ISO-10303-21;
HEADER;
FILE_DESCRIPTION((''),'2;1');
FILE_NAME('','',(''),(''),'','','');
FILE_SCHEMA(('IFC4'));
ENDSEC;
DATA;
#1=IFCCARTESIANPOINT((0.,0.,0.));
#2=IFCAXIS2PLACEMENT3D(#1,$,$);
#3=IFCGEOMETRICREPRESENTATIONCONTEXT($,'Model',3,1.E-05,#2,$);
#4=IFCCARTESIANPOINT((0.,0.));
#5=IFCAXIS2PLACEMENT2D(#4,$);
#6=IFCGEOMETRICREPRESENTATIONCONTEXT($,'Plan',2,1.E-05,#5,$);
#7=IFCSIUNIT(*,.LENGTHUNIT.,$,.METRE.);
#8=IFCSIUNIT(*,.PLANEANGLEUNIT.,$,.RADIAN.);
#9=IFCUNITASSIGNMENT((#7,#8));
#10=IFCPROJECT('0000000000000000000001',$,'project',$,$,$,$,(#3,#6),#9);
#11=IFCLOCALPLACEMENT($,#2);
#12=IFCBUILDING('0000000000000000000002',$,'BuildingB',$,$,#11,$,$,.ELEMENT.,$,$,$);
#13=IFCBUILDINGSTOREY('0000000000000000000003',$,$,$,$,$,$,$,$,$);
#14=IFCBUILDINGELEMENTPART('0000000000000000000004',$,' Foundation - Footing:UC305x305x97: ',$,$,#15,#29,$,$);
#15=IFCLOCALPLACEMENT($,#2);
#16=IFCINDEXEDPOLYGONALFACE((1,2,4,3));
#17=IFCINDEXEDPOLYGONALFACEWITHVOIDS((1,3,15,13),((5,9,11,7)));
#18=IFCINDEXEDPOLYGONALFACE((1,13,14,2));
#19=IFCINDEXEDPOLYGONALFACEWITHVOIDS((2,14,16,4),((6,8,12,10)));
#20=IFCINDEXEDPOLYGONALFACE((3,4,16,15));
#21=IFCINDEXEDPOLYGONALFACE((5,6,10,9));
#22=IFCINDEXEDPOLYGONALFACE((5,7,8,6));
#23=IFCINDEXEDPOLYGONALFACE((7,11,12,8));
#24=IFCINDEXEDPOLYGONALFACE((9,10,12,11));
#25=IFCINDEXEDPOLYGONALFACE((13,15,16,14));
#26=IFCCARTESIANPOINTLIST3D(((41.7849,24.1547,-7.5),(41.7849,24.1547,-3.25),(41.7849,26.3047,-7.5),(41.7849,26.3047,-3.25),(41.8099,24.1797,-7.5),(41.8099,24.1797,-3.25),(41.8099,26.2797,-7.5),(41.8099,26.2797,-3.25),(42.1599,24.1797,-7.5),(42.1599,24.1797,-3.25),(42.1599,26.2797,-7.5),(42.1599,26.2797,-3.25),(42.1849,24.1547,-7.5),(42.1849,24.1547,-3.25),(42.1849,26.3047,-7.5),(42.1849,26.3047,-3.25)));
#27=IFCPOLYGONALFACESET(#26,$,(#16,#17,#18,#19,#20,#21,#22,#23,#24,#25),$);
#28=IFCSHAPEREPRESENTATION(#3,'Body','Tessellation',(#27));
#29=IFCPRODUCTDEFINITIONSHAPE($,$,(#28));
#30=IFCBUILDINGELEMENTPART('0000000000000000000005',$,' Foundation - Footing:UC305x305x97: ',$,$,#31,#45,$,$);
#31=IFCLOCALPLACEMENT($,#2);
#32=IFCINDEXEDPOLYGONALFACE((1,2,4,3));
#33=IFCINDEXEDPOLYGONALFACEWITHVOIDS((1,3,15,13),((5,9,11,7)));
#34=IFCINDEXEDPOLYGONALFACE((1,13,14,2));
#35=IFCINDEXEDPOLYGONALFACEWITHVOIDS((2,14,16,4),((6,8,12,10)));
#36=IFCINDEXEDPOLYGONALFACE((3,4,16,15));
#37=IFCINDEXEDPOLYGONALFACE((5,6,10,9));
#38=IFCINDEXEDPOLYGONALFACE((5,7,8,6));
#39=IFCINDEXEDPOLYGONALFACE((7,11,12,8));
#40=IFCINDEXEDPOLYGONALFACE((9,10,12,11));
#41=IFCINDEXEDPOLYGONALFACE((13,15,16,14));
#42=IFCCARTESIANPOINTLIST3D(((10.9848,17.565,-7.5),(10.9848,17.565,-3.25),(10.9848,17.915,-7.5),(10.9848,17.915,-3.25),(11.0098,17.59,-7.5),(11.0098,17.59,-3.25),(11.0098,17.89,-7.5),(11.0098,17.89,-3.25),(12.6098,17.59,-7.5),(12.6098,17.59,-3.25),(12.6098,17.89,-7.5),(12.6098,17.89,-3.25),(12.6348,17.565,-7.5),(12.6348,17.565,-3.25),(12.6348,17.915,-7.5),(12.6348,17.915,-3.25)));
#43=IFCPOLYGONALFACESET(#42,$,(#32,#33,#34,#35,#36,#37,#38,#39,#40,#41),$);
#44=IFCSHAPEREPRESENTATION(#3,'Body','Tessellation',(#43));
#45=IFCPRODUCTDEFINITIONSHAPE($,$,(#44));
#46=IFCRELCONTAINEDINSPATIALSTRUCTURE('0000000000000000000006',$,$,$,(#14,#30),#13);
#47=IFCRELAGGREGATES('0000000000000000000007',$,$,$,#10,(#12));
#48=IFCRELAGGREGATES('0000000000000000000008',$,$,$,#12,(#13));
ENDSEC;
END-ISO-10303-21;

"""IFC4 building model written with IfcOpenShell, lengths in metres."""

from ifc_helpers import new_model, si_unit, origin, origin_2d, place, context, project, spatial, polyline, outline, extrude, element, save


model = new_model("IFC4")

# Units and contexts
model_context = context("Model", 3, precision=1e-05, world=origin())
plan_context = context("Plan", 2, precision=1e-05, world=origin_2d())
ifc_project = project(units=[si_unit("LENGTHUNIT", "METRE"), si_unit("PLANEANGLEUNIT", "RADIAN")], contexts=[model_context, plan_context])

# Building, storey
building_placement = place(None, origin())
building = spatial("IfcBuilding", under=ifc_project, at=building_placement, Name="BuildingB", CompositionType="ELEMENT")
storey = spatial("IfcBuildingStorey", under=building)

# Building element parts, openings
building_element_part_1 = element("IfcBuildingElementPart", 1, inside=storey, Name=" Foundation - Footing:UC305x305x97: ", context=model_context, shape_type="SweptSolid", body=[
    extrude(outline(polyline([(41.7849, 26.3047, -7.5), (42.1849, 26.3047, -7.5), (42.1849, 24.1547, -7.5), (41.7849, 24.1547, -7.5), (41.7849, 26.3047, -7.5)])), None, (0.0, 0.0, 1.0), 4.25),
])
element("IfcOpeningElement", 2, inside=storey, cuts=building_element_part_1, context=model_context, shape_type="SweptSolid", body=[
    extrude(outline(polyline([(41.8099, 26.2797, -7.5), (42.1599, 26.2797, -7.5), (42.1599, 24.1797, -7.5), (41.8099, 24.1797, -7.5), (41.8099, 26.2797, -7.5)])), None, (0.0, 0.0, 1.0), 4.25),
])
building_element_part_2 = element("IfcBuildingElementPart", 3, inside=storey, Name=" Foundation - Footing:UC305x305x97: ", context=model_context, shape_type="SweptSolid", body=[
    extrude(outline(polyline([(10.9848, 17.565, -7.5), (10.9848, 17.915, -7.5), (12.6348, 17.915, -7.5), (12.6348, 17.565, -7.5), (10.9848, 17.565, -7.5)])), None, (0.0, 0.0, 1.0), 4.25),
])
element("IfcOpeningElement", 4, inside=storey, cuts=building_element_part_2, context=model_context, shape_type="SweptSolid", body=[
    extrude(outline(polyline([(11.0098, 17.59, -7.5), (11.0098, 17.89, -7.5), (12.6098, 17.89, -7.5), (12.6098, 17.59, -7.5), (11.0098, 17.59, -7.5)])), None, (0.0, 0.0, 1.0), 4.25),
])

save(model, "model.ifc")
